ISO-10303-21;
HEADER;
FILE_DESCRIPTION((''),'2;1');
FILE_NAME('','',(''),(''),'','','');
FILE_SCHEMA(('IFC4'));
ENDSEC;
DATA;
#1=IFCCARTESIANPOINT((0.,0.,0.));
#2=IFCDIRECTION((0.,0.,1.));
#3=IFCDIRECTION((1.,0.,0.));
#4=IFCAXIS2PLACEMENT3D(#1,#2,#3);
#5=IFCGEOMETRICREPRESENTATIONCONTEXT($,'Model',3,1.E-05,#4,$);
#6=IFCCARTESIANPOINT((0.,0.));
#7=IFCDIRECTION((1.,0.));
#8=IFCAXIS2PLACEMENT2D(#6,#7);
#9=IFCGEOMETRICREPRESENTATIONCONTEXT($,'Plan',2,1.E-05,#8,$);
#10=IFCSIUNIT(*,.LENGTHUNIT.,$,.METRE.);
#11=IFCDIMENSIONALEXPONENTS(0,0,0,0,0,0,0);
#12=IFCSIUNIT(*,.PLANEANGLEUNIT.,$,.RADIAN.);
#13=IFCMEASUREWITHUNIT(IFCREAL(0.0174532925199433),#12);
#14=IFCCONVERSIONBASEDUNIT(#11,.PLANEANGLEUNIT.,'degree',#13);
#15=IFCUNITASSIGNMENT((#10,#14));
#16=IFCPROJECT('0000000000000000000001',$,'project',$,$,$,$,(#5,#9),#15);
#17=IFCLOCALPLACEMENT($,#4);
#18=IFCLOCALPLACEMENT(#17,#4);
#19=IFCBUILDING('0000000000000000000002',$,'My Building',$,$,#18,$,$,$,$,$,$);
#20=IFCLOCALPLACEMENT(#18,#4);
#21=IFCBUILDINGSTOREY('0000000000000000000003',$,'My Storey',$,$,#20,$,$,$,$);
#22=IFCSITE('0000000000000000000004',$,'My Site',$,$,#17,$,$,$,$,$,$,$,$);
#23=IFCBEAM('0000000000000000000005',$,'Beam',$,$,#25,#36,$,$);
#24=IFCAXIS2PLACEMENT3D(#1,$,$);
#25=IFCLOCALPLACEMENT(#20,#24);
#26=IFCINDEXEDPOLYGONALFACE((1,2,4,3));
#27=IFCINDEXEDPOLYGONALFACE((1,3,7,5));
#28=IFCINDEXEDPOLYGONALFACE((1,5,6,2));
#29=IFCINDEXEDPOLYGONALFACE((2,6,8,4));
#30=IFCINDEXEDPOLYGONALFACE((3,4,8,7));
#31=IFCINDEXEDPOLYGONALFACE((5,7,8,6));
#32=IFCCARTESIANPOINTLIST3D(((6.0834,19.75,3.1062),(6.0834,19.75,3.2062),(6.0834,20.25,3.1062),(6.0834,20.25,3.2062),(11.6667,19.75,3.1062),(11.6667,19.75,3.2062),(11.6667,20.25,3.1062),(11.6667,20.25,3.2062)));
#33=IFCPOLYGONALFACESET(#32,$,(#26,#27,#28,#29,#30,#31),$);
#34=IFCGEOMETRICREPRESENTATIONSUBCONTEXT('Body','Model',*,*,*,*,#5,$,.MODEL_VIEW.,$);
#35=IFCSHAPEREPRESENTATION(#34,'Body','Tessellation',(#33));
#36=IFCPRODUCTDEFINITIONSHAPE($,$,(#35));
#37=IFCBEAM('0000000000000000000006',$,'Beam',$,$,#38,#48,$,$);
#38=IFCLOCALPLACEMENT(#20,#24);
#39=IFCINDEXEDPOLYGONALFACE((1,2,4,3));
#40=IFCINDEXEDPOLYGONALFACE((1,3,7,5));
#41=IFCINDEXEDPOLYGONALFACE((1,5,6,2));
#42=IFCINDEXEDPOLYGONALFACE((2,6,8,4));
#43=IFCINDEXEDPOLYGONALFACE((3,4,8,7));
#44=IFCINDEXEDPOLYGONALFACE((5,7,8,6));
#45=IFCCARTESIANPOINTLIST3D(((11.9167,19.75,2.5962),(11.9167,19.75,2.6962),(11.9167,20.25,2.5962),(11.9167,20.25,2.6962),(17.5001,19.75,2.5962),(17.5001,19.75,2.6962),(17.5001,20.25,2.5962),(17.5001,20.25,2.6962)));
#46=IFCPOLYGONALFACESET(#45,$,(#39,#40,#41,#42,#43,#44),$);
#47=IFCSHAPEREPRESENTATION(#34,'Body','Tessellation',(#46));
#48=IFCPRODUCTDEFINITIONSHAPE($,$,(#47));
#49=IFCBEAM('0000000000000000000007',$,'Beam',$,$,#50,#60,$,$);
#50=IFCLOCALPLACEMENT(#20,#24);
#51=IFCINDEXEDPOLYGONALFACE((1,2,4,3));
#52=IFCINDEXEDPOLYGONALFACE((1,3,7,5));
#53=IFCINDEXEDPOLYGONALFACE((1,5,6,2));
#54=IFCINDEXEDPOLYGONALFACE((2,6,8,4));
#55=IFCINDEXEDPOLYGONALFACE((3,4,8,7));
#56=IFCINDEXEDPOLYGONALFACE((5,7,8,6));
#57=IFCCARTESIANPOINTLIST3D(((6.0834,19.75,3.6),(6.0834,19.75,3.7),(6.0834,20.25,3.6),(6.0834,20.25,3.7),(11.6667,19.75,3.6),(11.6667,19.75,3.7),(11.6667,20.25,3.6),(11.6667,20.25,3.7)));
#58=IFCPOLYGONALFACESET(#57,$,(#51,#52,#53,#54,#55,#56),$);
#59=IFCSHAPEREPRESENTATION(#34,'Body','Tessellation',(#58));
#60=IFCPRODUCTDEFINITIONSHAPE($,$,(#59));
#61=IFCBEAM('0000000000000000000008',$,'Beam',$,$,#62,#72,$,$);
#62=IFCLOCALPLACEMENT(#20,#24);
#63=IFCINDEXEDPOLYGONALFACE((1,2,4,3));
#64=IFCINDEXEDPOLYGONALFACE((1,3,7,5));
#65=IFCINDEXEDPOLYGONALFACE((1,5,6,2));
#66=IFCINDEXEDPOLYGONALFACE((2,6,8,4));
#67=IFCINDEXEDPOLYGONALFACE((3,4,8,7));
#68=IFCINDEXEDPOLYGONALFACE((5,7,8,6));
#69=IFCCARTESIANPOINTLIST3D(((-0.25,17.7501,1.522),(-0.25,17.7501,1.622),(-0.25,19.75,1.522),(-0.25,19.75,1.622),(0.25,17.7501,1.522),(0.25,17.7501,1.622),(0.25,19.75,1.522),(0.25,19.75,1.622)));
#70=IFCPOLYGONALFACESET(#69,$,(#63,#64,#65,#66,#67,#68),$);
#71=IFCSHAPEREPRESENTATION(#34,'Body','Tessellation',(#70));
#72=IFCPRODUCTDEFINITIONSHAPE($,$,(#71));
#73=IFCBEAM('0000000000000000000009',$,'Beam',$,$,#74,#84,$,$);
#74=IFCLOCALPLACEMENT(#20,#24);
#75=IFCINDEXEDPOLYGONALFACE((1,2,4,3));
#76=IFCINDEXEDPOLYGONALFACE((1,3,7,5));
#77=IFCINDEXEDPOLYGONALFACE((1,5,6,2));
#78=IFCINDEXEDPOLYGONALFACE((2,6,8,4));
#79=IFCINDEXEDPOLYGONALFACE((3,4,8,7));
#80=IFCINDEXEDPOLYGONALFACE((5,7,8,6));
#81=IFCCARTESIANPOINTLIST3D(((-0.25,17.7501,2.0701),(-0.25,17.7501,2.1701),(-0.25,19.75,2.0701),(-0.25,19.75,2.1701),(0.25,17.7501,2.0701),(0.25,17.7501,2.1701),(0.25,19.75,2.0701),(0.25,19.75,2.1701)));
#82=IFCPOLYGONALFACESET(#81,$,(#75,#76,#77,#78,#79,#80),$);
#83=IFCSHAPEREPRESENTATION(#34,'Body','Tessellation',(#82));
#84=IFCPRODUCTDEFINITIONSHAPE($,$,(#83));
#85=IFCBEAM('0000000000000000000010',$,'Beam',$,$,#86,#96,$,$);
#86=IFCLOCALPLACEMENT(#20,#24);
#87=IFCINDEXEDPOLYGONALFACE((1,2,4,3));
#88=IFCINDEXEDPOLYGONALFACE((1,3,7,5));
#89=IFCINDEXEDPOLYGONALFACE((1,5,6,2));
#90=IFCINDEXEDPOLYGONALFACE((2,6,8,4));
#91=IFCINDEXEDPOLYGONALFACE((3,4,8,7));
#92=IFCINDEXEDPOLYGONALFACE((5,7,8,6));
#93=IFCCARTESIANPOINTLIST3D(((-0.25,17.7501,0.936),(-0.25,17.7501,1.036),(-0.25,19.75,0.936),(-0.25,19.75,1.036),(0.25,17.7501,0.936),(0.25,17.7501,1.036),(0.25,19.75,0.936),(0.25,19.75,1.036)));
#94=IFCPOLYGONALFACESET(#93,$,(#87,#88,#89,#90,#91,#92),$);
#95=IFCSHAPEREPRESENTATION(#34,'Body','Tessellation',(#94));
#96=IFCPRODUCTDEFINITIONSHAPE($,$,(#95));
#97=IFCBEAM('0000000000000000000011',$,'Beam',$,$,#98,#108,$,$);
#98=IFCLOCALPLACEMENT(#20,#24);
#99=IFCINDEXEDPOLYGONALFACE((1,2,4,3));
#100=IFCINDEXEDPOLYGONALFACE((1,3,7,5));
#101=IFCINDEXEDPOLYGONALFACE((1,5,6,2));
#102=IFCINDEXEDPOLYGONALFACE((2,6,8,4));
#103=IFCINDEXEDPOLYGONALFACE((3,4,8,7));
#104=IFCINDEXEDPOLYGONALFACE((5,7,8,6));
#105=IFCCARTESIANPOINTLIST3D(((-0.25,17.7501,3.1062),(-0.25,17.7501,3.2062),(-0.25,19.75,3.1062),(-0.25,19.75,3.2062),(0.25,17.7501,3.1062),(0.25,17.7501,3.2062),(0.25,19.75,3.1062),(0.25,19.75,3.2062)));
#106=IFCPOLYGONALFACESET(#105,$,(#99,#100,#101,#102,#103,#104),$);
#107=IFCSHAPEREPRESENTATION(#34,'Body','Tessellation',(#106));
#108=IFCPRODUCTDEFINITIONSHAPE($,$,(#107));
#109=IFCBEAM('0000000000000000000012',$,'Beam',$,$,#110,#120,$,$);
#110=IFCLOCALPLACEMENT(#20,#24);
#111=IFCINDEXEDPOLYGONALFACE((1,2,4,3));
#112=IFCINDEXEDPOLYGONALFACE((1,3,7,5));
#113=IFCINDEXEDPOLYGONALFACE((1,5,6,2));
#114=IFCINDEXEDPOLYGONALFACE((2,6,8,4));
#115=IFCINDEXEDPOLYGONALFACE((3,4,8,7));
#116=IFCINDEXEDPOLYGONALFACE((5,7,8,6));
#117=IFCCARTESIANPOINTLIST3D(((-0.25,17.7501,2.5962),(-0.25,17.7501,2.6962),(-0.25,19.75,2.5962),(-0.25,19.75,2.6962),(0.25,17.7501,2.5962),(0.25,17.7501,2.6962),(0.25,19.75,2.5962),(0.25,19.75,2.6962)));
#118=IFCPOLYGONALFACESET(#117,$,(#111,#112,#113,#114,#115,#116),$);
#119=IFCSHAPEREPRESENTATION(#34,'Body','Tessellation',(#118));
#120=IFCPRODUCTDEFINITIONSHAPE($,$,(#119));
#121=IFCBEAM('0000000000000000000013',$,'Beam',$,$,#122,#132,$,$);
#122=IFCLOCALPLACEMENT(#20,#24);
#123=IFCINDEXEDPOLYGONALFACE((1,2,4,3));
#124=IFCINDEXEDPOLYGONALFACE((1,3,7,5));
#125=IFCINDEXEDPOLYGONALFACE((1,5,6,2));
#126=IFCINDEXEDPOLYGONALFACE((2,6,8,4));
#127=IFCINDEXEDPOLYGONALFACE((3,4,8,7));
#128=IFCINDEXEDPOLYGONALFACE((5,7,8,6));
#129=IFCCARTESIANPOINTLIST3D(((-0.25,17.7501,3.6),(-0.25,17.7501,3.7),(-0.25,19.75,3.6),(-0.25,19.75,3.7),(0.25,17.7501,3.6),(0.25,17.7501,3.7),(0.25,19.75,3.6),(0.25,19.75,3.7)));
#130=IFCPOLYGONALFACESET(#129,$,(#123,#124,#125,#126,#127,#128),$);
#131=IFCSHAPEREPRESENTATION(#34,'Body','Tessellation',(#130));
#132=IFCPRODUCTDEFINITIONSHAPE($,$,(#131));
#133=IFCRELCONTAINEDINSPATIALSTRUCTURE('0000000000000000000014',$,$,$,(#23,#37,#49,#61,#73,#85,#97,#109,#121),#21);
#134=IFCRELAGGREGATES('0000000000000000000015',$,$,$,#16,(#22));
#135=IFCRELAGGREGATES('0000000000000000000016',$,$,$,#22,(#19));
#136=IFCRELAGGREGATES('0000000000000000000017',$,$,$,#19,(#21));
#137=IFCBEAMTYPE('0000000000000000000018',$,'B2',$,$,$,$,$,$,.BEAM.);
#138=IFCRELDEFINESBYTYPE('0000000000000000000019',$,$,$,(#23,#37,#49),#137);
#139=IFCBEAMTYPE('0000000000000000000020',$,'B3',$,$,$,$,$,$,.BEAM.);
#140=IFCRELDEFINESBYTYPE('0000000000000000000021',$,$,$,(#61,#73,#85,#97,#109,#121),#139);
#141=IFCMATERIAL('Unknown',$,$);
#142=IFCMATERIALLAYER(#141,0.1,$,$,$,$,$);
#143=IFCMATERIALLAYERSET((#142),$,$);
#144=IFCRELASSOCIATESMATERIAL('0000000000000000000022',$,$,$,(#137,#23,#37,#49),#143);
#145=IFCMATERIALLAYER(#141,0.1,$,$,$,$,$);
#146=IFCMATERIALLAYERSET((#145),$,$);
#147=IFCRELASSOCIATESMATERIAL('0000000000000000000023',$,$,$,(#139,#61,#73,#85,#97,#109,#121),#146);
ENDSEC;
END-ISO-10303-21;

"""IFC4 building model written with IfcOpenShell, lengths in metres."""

from ifc_helpers import new_model, entity, si_unit, converted_unit, frame, origin_with_axes, origin_2d_with_axis, place, context, subcontext, project, spatial, indexed_curve, outline, extrude, material, layer, layer_set, layer_usage, type_object, element, save


model = new_model("IFC4")

# Units and contexts
model_context = context("Model", 3, precision=1e-05, world=origin_with_axes())
plan_context = context("Plan", 2, precision=1e-05, world=origin_2d_with_axis())
body_context = subcontext(model_context, "Body", "Model", "MODEL_VIEW")
ifc_project = project(units=[si_unit("LENGTHUNIT", "METRE"), converted_unit("PLANEANGLEUNIT", "degree", entity("IfcReal", 0.0174532925199433), si_unit("PLANEANGLEUNIT", "RADIAN"), dimensions=[0, 0, 0, 0, 0, 0, 0])], contexts=[model_context, plan_context])

# Site, building, storey
site_placement = place(None, origin_with_axes())
site = spatial("IfcSite", under=ifc_project, at=site_placement, Name="My Site")
building_placement = place(site_placement, origin_with_axes())
building = spatial("IfcBuilding", under=site, at=building_placement, Name="My Building")
storey_placement = place(building_placement, origin_with_axes())
storey = spatial("IfcBuildingStorey", under=building, at=storey_placement, Name="My Storey")

# Shared definitions
ifc_material = material(Name="Unknown")

# Beams
ifc_layer_1 = layer(ifc_material, 0.1)
ifc_layer_set_1 = layer_set([ifc_layer_1])
beam_type_1 = type_object("IfcBeamType", Name="B2", PredefinedType="BEAM", material=ifc_layer_set_1)
ifc_layer_usage_1 = layer_usage(ifc_layer_set_1, "AXIS3", "POSITIVE", -0.1)
beam_1_placement = place(storey_placement, frame((6.0834, 20.25, 3.2062), z_axis=(0.0, 0.0, 1.0), x_axis=(1.0, 0.0, 0.0)))
element("IfcBeam", 1, at=beam_1_placement, inside=storey, type_object=beam_type_1, material=ifc_layer_usage_1, Name="Beam", context=body_context, shape_type="SweptSolid", body=[
    extrude(outline(indexed_curve([(0.0, 0.0), (0.0, -0.5), (5.5833, -0.5), (5.5834, 0.0), (0.0, 0.0)])), frame((0.0, 0.0, -0.1), z_axis=(0.0, 0.0, 1.0), x_axis=(1.0, 0.0, 0.0)), (0.0, 0.0, 1.0), 0.1),
])
ifc_layer_usage_2 = layer_usage(ifc_layer_set_1, "AXIS3", "POSITIVE", -0.1)
beam_2_placement = place(storey_placement, frame((11.9167, 20.25, 2.6962), z_axis=(0.0, 0.0, 1.0), x_axis=(1.0, 0.0, 0.0)))
element("IfcBeam", 2, at=beam_2_placement, inside=storey, type_object=beam_type_1, material=ifc_layer_usage_2, Name="Beam", context=body_context, shape_type="SweptSolid", body=[
    extrude(outline(indexed_curve([(0.0, 0.0), (0.0, -0.5), (5.5833, -0.5), (5.5834, 0.0), (0.0, 0.0)])), frame((0.0, 0.0, -0.1), z_axis=(0.0, 0.0, 1.0), x_axis=(1.0, 0.0, 0.0)), (0.0, 0.0, 1.0), 0.1),
])
ifc_layer_usage_3 = layer_usage(ifc_layer_set_1, "AXIS3", "POSITIVE", -0.1)
beam_3_placement = place(storey_placement, frame((6.0834, 20.25, 3.7), z_axis=(0.0, 0.0, 1.0), x_axis=(1.0, 0.0, 0.0)))
element("IfcBeam", 3, at=beam_3_placement, inside=storey, type_object=beam_type_1, material=ifc_layer_usage_3, Name="Beam", context=body_context, shape_type="SweptSolid", body=[
    extrude(outline(indexed_curve([(0.0, 0.0), (0.0, -0.5), (5.5833, -0.5), (5.5834, 0.0), (0.0, 0.0)])), frame((0.0, 0.0, -0.1), z_axis=(0.0, 0.0, 1.0), x_axis=(1.0, 0.0, 0.0)), (0.0, 0.0, 1.0), 0.1),
])
ifc_layer_2 = layer(ifc_material, 0.1)
ifc_layer_set_2 = layer_set([ifc_layer_2])
ifc_layer_usage_4 = layer_usage(ifc_layer_set_2, "AXIS3", "POSITIVE", -0.1)
beam_type_2 = type_object("IfcBeamType", Name="B3", PredefinedType="BEAM", material=ifc_layer_set_2)
beam_4_placement = place(storey_placement, frame((0.25, 17.7501, 1.622), z_axis=(0.0, 0.0, 1.0), x_axis=(0.0, 1.0, 0.0)))
element("IfcBeam", 4, at=beam_4_placement, inside=storey, type_object=beam_type_2, material=ifc_layer_usage_4, Name="Beam", context=body_context, shape_type="SweptSolid", body=[
    extrude(outline(indexed_curve([(0.0, 0.0), (0.0, 0.5), (1.9999, 0.5), (1.9999, 0.0), (0.0, 0.0)])), frame((0.0, 0.0, -0.1), z_axis=(0.0, 0.0, 1.0), x_axis=(1.0, 0.0, 0.0)), (0.0, 0.0, 1.0), 0.1),
])
ifc_layer_usage_5 = layer_usage(ifc_layer_set_2, "AXIS3", "POSITIVE", -0.1)
beam_5_placement = place(storey_placement, frame((0.25, 17.7501, 2.1701), z_axis=(0.0, 0.0, 1.0), x_axis=(0.0, 1.0, 0.0)))
element("IfcBeam", 5, at=beam_5_placement, inside=storey, type_object=beam_type_2, material=ifc_layer_usage_5, Name="Beam", context=body_context, shape_type="SweptSolid", body=[
    extrude(outline(indexed_curve([(0.0, 0.0), (0.0, 0.5), (1.9999, 0.5), (1.9999, 0.0), (0.0, 0.0)])), frame((0.0, 0.0, -0.1), z_axis=(0.0, 0.0, 1.0), x_axis=(1.0, 0.0, 0.0)), (0.0, 0.0, 1.0), 0.1),
])
ifc_layer_usage_6 = layer_usage(ifc_layer_set_2, "AXIS3", "POSITIVE", -0.1)
beam_6_placement = place(storey_placement, frame((0.25, 17.7501, 1.036), z_axis=(0.0, 0.0, 1.0), x_axis=(0.0, 1.0, 0.0)))
element("IfcBeam", 6, at=beam_6_placement, inside=storey, type_object=beam_type_2, material=ifc_layer_usage_6, Name="Beam", context=body_context, shape_type="SweptSolid", body=[
    extrude(outline(indexed_curve([(0.0, 0.0), (0.0, 0.5), (1.9999, 0.5), (1.9999, 0.0), (0.0, 0.0)])), frame((0.0, 0.0, -0.1), z_axis=(0.0, 0.0, 1.0), x_axis=(1.0, 0.0, 0.0)), (0.0, 0.0, 1.0), 0.1),
])
ifc_layer_usage_7 = layer_usage(ifc_layer_set_2, "AXIS3", "POSITIVE", -0.1)
beam_7_placement = place(storey_placement, frame((0.25, 17.7501, 3.2062), z_axis=(0.0, 0.0, 1.0), x_axis=(0.0, 1.0, 0.0)))
element("IfcBeam", 7, at=beam_7_placement, inside=storey, type_object=beam_type_2, material=ifc_layer_usage_7, Name="Beam", context=body_context, shape_type="SweptSolid", body=[
    extrude(outline(indexed_curve([(0.0, 0.0), (0.0, 0.5), (1.9999, 0.5), (1.9999, 0.0), (0.0, 0.0)])), frame((0.0, 0.0, -0.1), z_axis=(0.0, 0.0, 1.0), x_axis=(1.0, 0.0, 0.0)), (0.0, 0.0, 1.0), 0.1),
])
ifc_layer_usage_8 = layer_usage(ifc_layer_set_2, "AXIS3", "POSITIVE", -0.1)
beam_8_placement = place(storey_placement, frame((0.25, 17.7501, 2.6962), z_axis=(0.0, 0.0, 1.0), x_axis=(0.0, 1.0, 0.0)))
element("IfcBeam", 8, at=beam_8_placement, inside=storey, type_object=beam_type_2, material=ifc_layer_usage_8, Name="Beam", context=body_context, shape_type="SweptSolid", body=[
    extrude(outline(indexed_curve([(0.0, 0.0), (0.0, 0.5), (1.9999, 0.5), (1.9999, 0.0), (0.0, 0.0)])), frame((0.0, 0.0, -0.1), z_axis=(0.0, 0.0, 1.0), x_axis=(1.0, 0.0, 0.0)), (0.0, 0.0, 1.0), 0.1),
])
ifc_layer_usage_9 = layer_usage(ifc_layer_set_2, "AXIS3", "POSITIVE", -0.1)
beam_9_placement = place(storey_placement, frame((0.25, 17.7501, 3.7), z_axis=(0.0, 0.0, 1.0), x_axis=(0.0, 1.0, 0.0)))
element("IfcBeam", 9, at=beam_9_placement, inside=storey, type_object=beam_type_2, material=ifc_layer_usage_9, Name="Beam", context=body_context, shape_type="SweptSolid", body=[
    extrude(outline(indexed_curve([(0.0, 0.0), (0.0, 0.5), (1.9999, 0.5), (1.9999, 0.0), (0.0, 0.0)])), frame((0.0, 0.0, -0.1), z_axis=(0.0, 0.0, 1.0), x_axis=(1.0, 0.0, 0.0)), (0.0, 0.0, 1.0), 0.1),
])

save(model, "model.ifc")
